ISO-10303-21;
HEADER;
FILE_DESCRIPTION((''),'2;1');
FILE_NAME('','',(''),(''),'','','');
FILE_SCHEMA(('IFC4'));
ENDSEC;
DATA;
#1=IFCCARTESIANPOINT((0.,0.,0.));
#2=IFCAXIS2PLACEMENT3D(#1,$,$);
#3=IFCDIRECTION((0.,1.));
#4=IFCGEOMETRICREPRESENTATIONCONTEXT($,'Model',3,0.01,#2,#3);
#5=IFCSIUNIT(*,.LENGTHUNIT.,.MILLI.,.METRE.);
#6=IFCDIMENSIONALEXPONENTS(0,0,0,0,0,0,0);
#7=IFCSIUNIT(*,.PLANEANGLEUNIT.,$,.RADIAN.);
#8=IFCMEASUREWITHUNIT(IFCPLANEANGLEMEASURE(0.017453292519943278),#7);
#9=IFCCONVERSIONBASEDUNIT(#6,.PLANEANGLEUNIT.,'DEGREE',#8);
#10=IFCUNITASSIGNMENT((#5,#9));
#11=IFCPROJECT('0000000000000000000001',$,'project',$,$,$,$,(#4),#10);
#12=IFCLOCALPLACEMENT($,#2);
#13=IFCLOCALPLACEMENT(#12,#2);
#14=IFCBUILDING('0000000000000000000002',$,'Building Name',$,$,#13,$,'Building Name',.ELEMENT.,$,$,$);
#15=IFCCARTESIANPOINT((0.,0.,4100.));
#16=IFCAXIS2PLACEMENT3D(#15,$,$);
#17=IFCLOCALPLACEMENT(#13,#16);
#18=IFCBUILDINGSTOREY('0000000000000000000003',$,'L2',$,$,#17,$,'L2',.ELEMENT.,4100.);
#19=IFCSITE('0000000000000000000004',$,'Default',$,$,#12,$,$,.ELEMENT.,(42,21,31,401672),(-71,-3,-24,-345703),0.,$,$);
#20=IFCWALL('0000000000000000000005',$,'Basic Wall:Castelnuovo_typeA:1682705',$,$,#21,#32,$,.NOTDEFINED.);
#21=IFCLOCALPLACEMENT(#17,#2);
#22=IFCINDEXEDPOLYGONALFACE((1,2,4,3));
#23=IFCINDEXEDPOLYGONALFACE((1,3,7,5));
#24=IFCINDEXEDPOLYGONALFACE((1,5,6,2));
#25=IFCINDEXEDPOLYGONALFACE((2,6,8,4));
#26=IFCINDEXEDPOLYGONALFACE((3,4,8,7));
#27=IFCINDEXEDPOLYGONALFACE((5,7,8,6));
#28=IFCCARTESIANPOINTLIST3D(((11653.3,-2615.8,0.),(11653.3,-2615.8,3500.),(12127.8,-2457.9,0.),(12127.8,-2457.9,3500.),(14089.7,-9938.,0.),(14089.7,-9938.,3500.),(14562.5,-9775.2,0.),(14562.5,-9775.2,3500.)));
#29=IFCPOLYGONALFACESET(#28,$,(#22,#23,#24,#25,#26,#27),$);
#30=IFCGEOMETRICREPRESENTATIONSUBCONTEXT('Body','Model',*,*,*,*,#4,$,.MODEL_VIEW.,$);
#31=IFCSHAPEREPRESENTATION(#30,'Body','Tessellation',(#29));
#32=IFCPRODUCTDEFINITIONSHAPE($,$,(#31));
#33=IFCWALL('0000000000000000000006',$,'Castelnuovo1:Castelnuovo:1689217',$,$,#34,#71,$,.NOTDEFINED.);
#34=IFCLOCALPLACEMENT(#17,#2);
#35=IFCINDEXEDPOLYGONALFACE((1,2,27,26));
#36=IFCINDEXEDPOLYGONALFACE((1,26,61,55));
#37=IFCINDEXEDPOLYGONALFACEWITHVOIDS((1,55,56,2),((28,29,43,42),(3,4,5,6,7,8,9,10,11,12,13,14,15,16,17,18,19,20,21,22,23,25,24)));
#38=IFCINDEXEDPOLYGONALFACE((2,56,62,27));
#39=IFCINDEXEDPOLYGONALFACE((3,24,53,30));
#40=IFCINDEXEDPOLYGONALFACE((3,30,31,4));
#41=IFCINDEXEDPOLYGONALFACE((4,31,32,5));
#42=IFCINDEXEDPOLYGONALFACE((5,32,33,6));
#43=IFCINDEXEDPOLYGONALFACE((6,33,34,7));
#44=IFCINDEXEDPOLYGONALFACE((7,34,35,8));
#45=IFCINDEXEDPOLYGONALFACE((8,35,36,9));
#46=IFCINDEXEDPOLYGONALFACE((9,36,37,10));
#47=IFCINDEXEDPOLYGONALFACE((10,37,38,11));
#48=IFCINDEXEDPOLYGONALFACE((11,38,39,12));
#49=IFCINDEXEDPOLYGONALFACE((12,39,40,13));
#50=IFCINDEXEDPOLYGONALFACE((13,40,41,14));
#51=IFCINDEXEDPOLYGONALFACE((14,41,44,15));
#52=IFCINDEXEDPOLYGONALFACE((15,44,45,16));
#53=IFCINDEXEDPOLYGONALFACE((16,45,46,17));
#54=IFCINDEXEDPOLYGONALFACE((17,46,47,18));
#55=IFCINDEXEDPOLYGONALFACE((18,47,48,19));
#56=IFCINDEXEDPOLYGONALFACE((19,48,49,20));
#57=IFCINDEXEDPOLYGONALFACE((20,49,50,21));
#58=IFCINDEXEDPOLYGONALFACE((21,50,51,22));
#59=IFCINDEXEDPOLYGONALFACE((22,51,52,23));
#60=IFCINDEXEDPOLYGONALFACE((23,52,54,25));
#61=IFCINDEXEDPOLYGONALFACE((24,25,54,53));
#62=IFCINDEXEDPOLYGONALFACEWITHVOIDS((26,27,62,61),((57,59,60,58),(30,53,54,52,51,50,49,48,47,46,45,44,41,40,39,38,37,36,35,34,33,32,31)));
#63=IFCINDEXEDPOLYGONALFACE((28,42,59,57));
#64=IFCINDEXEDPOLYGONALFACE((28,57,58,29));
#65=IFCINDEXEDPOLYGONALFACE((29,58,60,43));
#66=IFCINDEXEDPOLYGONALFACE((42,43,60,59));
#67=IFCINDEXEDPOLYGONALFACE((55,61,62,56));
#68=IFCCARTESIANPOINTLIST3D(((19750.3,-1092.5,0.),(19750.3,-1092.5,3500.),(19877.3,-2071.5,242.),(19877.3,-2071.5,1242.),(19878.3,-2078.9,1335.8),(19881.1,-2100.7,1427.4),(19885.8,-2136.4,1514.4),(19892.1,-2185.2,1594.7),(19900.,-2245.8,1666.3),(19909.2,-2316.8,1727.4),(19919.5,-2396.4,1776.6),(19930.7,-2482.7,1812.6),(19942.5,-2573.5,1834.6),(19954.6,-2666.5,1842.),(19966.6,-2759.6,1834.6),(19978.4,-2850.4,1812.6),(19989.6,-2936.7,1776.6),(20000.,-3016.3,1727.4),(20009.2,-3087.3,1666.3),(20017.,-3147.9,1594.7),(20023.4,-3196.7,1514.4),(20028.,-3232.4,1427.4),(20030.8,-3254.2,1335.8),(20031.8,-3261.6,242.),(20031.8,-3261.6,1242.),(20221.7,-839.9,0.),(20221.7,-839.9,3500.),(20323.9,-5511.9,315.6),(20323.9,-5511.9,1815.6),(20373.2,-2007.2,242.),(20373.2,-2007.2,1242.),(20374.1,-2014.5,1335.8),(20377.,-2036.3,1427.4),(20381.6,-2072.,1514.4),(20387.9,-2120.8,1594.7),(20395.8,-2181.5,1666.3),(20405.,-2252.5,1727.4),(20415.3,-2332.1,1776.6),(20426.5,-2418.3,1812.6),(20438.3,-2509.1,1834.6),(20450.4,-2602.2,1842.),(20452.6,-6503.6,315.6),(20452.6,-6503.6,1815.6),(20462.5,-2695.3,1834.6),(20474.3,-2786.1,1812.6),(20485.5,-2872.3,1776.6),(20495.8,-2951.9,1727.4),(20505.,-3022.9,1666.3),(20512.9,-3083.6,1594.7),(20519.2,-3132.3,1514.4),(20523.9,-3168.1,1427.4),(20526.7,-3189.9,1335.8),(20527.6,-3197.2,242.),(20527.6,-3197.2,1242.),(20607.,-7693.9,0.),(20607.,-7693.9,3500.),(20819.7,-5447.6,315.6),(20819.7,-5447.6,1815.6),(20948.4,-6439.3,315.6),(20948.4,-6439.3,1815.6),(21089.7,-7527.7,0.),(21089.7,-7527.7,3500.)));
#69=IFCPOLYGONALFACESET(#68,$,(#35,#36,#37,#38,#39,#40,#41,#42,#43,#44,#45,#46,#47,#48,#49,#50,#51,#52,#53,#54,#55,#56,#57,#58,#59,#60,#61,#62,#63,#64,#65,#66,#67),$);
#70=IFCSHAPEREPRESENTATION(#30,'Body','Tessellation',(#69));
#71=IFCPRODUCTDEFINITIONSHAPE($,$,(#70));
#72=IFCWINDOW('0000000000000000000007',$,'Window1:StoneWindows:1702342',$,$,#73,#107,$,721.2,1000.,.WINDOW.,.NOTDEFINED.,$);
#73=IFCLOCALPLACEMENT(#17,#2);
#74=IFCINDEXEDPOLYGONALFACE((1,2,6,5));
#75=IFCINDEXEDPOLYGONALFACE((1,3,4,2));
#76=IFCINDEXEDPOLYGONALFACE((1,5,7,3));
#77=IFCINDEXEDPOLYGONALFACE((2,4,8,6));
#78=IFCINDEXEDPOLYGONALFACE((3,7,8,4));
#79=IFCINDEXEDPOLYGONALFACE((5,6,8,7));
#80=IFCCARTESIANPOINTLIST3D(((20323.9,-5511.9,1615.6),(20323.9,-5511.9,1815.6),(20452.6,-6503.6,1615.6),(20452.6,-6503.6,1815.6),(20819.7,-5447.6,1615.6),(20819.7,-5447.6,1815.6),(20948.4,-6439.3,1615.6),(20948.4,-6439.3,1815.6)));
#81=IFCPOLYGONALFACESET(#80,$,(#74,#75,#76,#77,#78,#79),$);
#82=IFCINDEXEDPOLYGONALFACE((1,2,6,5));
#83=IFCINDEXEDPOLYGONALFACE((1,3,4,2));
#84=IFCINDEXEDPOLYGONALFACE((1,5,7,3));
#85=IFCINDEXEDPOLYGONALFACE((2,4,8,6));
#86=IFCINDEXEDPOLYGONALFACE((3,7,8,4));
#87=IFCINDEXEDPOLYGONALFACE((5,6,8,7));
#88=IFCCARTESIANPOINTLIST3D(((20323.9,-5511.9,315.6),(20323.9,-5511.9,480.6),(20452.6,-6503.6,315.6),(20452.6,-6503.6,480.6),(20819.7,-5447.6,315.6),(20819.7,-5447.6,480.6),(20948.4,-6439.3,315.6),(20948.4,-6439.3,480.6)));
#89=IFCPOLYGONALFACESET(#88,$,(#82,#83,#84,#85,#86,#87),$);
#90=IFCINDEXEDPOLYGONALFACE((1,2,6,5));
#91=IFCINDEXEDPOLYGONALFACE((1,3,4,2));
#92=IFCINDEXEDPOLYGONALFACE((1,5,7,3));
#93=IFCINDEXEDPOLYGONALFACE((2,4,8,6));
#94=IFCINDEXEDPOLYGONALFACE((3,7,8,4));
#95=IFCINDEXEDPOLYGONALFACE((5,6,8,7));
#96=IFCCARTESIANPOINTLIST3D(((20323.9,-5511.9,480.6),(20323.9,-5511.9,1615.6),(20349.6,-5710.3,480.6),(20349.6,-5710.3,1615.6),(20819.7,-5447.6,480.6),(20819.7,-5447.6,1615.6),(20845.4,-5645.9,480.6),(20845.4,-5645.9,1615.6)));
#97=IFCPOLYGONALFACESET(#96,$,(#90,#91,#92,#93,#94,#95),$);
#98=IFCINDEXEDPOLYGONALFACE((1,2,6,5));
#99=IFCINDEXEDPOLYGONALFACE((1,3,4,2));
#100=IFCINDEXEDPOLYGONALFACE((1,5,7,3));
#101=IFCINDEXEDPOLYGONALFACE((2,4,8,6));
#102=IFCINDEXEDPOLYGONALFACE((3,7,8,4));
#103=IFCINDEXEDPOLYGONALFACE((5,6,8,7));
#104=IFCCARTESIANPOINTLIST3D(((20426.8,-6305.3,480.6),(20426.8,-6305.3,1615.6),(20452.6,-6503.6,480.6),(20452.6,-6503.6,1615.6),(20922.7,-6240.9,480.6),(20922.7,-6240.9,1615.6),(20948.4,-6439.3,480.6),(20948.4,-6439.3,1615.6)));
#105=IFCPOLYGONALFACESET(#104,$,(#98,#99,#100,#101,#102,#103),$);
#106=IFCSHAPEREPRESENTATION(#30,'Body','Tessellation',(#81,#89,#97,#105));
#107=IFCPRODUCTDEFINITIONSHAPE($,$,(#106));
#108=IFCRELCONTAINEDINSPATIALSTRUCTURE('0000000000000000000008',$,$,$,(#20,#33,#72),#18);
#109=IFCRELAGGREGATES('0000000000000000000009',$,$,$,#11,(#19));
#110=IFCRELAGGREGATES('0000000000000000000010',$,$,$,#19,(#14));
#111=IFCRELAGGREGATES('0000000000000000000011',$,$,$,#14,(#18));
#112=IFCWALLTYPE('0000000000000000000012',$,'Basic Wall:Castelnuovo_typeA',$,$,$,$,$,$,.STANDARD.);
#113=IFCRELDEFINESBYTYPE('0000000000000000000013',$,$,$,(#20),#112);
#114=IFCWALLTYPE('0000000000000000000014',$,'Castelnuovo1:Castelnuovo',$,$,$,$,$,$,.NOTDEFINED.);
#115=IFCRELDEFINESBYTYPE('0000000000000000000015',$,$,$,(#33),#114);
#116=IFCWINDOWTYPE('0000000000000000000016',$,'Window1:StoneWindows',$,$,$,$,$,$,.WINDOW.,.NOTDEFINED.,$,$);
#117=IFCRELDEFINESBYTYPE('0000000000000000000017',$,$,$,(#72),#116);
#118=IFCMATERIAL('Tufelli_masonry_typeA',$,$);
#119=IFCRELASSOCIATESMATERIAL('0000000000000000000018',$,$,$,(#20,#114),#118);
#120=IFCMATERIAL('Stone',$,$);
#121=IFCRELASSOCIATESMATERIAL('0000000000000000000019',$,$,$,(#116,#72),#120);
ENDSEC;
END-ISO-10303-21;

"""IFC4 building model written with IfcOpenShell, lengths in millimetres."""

from ifc_helpers import new_model, entity, si_unit, converted_unit, direction, frame, origin, place, context, subcontext, project, spatial, line, arc, indexed_curve, outline, extrude, source, transform, mapped, material, type_object, type_shapes, element, save


model = new_model("IFC4")

# Units and contexts
model_context = context("Model", 3, precision=0.01, world=origin(), true_north=direction((0.0, 1.0)))
body_context = subcontext(model_context, "Body", "Model", "MODEL_VIEW")
ifc_project = project(units=[si_unit("LENGTHUNIT", "METRE", prefix="MILLI"), converted_unit("PLANEANGLEUNIT", "DEGREE", entity("IfcPlaneAngleMeasure", 0.017453292519943278), si_unit("PLANEANGLEUNIT", "RADIAN"), dimensions=[0, 0, 0, 0, 0, 0, 0])], contexts=[model_context])

# Site, building, storey
site_placement = place(None, origin())
site = spatial("IfcSite", under=ifc_project, at=site_placement, Name="Default", CompositionType="ELEMENT", RefLatitude=(42, 21, 31, 401672), RefLongitude=(-71, -3, -24, -345703), RefElevation=0.0)
building_placement = place(site_placement, origin())
building = spatial("IfcBuilding", under=site, at=building_placement, Name="Building Name", LongName="Building Name", CompositionType="ELEMENT")
storey_placement = place(building_placement, frame((0.0, 0.0, 4100.0)))
storey = spatial("IfcBuildingStorey", under=building, at=storey_placement, Name="L2", LongName="L2", CompositionType="ELEMENT", Elevation=4100.0)

# Wall
ifc_material_1 = material(Name="Tufelli_masonry_typeA")
wall_type_1 = type_object("IfcWallType", Name="Basic Wall:Castelnuovo_typeA", PredefinedType="STANDARD")
wall_1_placement = place(storey_placement, frame((11890.5, -2536.8, 0.0), z_axis=(0.0, 0.0, 1.0), x_axis=(0.315716, -0.948854, 0.0)))
element("IfcWall", 1, at=wall_1_placement, inside=storey, type_object=wall_type_1, material=ifc_material_1, Name="Basic Wall:Castelnuovo_typeA:1682705", PredefinedType="NOTDEFINED", context=body_context, shape_type="SweptSolid", body=[
    extrude(outline(indexed_curve([(7716.9, -250.0), (7711.7, 250.0), (0.0, 250.0), (0.0, -250.0), (7716.9, -250.0)], self_intersect=False)), origin(), (0.0, 0.0, 1.0), 3500.0),
])

# Wall, openings
wall_type_2 = type_object("IfcWallType", Name="Castelnuovo1:Castelnuovo", PredefinedType="NOTDEFINED", material=ifc_material_1)
wall_2_placement = place(storey_placement, frame((19750.3, -7693.9, 0.0), z_axis=(0.0, 0.0, 1.0), x_axis=(0.0, 1.0, 0.0)))
wall_2 = element("IfcWall", 2, at=wall_2_placement, inside=storey, type_object=wall_type_2, Name="Castelnuovo1:Castelnuovo:1689217", PredefinedType="NOTDEFINED", context=body_context, shape_type="SweptSolid", body=[
    extrude(outline(indexed_curve([(-929.1, -3281.7), (-418.7, -3281.7), (937.9, 3324.4), (409.9, 3239.0), (-929.1, -3281.7)], self_intersect=False)), frame((3405.4, -666.9, 0.0), z_axis=(0.0, 0.0, 1.0), x_axis=(0.325568, -0.945519, 0.0)), (0.0, 0.0, 1.0), 3500.0),
])
opening_1_placement = place(wall_2_placement, origin())
element("IfcOpeningElement", 3, at=opening_1_placement, cuts=wall_2, PredefinedType="OPENING", context=body_context, shape_type="SweptSolid", body=[
    extrude(outline(indexed_curve([(-750.0, -500.0), (750.0, -500.0), (750.0, 500.0), (-750.0, 500.0), (-750.0, -500.0)], self_intersect=False)), frame((1683.5, -618.1, 1065.6), z_axis=(0.128709, -0.991682, 0.0), x_axis=(0.0, 0.0, 1.0)), (0.0, 0.0, 1.0), 590.0),
])
opening_2_placement = place(wall_2_placement, origin())
element("IfcOpeningElement", 4, at=opening_2_placement, cuts=wall_2, PredefinedType="OPENING", context=body_context, shape_type="SweptSolid", body=[
    extrude(outline(indexed_curve([(-750.0, -500.0), (750.0, -500.0), (750.0, 500.0), (-750.0, 500.0), (-750.0, -500.0)], self_intersect=False)), frame((1753.0, -1153.6, 1065.6), z_axis=(-0.128709, 0.991682, 0.0), x_axis=(0.0, 0.0, 1.0)), (0.0, 0.0, 1.0), 590.0),
])
opening_3_placement = place(wall_2_placement, origin())
element("IfcOpeningElement", 5, at=opening_3_placement, cuts=wall_2, PredefinedType="OPENING", context=body_context, shape_type="SweptSolid", body=[
    extrude(outline(indexed_curve([(-750.0, -500.0), (750.0, -500.0), (750.0, 500.0), (-750.0, 500.0), (-750.0, -500.0)], self_intersect=False)), frame((1683.5, -618.1, 1065.6), z_axis=(0.128709, -0.991682, 0.0), x_axis=(0.0, 0.0, 1.0)), (0.0, 0.0, 1.0), 590.0),
])
opening_4_placement = place(wall_2_placement, origin())
element("IfcOpeningElement", 6, at=opening_4_placement, cuts=wall_2, PredefinedType="OPENING", context=body_context, shape_type="SweptSolid", body=[
    extrude(outline(indexed_curve([(-500.0, -600.0), (500.0, -600.0), (1100.0, 0.0), (500.0, 600.0), (-500.0, 600.0)], segments=[line(1, 2), arc(2, 3, 4), line(4, 5, 1)], self_intersect=False)), frame((5024.7, -184.5, 742.0), z_axis=(0.128709, -0.991682, 0.0), x_axis=(0.0, 0.0, 1.0)), (0.0, 0.0, 1.0), 590.0),
])

# Window
ifc_material_2 = material(Name="Stone")
window_type_1 = type_object("IfcWindowType", Name="Window1:StoneWindows", PartitioningType="NOTDEFINED", PredefinedType="WINDOW", material=ifc_material_2)
shared_shape_1 = source(origin(), body_context, "Body", "SweptSolid", [
    extrude(outline(indexed_curve([(-250.0, -500.0), (250.0, -500.0), (250.0, 500.0), (-250.0, 500.0), (-250.0, -500.0)], self_intersect=False)), frame((0.0, 0.0, 2100.0), z_axis=(0.0, 0.0, 1.0), x_axis=(0.0, 1.0, 0.0)), (0.0, 0.0, 1.0), 200.0),
    extrude(outline(indexed_curve([(-250.0, -500.0), (250.0, -500.0), (250.0, 500.0), (-250.0, 500.0), (-250.0, -500.0)], self_intersect=False)), frame((0.0, 0.0, 800.0), z_axis=(0.0, 0.0, 1.0), x_axis=(0.0, 1.0, 0.0)), (0.0, 0.0, 1.0), 165.0),
    extrude(outline(indexed_curve([(-250.0, -100.0), (250.0, -100.0), (250.0, 100.0), (-250.0, 100.0), (-250.0, -100.0)], self_intersect=False)), frame((-400.0, 0.0, 965.0), z_axis=(0.0, 0.0, 1.0), x_axis=(0.0, 1.0, 0.0)), (0.0, 0.0, 1.0), 1135.0),
    extrude(outline(indexed_curve([(-250.0, -100.0), (250.0, -100.0), (250.0, 100.0), (-250.0, 100.0), (-250.0, -100.0)], self_intersect=False)), frame((400.0, 0.0, 965.0), z_axis=(0.0, 0.0, 1.0), x_axis=(0.0, 1.0, 0.0)), (0.0, 0.0, 1.0), 1135.0),
])
type_shapes(window_type_1, [shared_shape_1])
for number, where, z_axis, x_axis, name in (
    (7, (20636.1, -5975.6, -484.4), (0.0, 0.0, 1.0), (0.128709, -0.991682, 0.0), "Window1:StoneWindows:1702342"),
):
    element("IfcWindow", number, at=place(storey_placement, frame(where, z_axis=z_axis, x_axis=x_axis)), inside=storey, type_object=window_type_1, material=ifc_material_2, Name=name, OverallHeight=721.2, OverallWidth=1000.0, PartitioningType="NOTDEFINED", PredefinedType="WINDOW", context=body_context, shape_type="MappedRepresentation", body=[
        mapped(shared_shape_1, transform((0.0, 0.0, 0.0), scale=1.0)),
    ])

save(model, "model.ifc")
